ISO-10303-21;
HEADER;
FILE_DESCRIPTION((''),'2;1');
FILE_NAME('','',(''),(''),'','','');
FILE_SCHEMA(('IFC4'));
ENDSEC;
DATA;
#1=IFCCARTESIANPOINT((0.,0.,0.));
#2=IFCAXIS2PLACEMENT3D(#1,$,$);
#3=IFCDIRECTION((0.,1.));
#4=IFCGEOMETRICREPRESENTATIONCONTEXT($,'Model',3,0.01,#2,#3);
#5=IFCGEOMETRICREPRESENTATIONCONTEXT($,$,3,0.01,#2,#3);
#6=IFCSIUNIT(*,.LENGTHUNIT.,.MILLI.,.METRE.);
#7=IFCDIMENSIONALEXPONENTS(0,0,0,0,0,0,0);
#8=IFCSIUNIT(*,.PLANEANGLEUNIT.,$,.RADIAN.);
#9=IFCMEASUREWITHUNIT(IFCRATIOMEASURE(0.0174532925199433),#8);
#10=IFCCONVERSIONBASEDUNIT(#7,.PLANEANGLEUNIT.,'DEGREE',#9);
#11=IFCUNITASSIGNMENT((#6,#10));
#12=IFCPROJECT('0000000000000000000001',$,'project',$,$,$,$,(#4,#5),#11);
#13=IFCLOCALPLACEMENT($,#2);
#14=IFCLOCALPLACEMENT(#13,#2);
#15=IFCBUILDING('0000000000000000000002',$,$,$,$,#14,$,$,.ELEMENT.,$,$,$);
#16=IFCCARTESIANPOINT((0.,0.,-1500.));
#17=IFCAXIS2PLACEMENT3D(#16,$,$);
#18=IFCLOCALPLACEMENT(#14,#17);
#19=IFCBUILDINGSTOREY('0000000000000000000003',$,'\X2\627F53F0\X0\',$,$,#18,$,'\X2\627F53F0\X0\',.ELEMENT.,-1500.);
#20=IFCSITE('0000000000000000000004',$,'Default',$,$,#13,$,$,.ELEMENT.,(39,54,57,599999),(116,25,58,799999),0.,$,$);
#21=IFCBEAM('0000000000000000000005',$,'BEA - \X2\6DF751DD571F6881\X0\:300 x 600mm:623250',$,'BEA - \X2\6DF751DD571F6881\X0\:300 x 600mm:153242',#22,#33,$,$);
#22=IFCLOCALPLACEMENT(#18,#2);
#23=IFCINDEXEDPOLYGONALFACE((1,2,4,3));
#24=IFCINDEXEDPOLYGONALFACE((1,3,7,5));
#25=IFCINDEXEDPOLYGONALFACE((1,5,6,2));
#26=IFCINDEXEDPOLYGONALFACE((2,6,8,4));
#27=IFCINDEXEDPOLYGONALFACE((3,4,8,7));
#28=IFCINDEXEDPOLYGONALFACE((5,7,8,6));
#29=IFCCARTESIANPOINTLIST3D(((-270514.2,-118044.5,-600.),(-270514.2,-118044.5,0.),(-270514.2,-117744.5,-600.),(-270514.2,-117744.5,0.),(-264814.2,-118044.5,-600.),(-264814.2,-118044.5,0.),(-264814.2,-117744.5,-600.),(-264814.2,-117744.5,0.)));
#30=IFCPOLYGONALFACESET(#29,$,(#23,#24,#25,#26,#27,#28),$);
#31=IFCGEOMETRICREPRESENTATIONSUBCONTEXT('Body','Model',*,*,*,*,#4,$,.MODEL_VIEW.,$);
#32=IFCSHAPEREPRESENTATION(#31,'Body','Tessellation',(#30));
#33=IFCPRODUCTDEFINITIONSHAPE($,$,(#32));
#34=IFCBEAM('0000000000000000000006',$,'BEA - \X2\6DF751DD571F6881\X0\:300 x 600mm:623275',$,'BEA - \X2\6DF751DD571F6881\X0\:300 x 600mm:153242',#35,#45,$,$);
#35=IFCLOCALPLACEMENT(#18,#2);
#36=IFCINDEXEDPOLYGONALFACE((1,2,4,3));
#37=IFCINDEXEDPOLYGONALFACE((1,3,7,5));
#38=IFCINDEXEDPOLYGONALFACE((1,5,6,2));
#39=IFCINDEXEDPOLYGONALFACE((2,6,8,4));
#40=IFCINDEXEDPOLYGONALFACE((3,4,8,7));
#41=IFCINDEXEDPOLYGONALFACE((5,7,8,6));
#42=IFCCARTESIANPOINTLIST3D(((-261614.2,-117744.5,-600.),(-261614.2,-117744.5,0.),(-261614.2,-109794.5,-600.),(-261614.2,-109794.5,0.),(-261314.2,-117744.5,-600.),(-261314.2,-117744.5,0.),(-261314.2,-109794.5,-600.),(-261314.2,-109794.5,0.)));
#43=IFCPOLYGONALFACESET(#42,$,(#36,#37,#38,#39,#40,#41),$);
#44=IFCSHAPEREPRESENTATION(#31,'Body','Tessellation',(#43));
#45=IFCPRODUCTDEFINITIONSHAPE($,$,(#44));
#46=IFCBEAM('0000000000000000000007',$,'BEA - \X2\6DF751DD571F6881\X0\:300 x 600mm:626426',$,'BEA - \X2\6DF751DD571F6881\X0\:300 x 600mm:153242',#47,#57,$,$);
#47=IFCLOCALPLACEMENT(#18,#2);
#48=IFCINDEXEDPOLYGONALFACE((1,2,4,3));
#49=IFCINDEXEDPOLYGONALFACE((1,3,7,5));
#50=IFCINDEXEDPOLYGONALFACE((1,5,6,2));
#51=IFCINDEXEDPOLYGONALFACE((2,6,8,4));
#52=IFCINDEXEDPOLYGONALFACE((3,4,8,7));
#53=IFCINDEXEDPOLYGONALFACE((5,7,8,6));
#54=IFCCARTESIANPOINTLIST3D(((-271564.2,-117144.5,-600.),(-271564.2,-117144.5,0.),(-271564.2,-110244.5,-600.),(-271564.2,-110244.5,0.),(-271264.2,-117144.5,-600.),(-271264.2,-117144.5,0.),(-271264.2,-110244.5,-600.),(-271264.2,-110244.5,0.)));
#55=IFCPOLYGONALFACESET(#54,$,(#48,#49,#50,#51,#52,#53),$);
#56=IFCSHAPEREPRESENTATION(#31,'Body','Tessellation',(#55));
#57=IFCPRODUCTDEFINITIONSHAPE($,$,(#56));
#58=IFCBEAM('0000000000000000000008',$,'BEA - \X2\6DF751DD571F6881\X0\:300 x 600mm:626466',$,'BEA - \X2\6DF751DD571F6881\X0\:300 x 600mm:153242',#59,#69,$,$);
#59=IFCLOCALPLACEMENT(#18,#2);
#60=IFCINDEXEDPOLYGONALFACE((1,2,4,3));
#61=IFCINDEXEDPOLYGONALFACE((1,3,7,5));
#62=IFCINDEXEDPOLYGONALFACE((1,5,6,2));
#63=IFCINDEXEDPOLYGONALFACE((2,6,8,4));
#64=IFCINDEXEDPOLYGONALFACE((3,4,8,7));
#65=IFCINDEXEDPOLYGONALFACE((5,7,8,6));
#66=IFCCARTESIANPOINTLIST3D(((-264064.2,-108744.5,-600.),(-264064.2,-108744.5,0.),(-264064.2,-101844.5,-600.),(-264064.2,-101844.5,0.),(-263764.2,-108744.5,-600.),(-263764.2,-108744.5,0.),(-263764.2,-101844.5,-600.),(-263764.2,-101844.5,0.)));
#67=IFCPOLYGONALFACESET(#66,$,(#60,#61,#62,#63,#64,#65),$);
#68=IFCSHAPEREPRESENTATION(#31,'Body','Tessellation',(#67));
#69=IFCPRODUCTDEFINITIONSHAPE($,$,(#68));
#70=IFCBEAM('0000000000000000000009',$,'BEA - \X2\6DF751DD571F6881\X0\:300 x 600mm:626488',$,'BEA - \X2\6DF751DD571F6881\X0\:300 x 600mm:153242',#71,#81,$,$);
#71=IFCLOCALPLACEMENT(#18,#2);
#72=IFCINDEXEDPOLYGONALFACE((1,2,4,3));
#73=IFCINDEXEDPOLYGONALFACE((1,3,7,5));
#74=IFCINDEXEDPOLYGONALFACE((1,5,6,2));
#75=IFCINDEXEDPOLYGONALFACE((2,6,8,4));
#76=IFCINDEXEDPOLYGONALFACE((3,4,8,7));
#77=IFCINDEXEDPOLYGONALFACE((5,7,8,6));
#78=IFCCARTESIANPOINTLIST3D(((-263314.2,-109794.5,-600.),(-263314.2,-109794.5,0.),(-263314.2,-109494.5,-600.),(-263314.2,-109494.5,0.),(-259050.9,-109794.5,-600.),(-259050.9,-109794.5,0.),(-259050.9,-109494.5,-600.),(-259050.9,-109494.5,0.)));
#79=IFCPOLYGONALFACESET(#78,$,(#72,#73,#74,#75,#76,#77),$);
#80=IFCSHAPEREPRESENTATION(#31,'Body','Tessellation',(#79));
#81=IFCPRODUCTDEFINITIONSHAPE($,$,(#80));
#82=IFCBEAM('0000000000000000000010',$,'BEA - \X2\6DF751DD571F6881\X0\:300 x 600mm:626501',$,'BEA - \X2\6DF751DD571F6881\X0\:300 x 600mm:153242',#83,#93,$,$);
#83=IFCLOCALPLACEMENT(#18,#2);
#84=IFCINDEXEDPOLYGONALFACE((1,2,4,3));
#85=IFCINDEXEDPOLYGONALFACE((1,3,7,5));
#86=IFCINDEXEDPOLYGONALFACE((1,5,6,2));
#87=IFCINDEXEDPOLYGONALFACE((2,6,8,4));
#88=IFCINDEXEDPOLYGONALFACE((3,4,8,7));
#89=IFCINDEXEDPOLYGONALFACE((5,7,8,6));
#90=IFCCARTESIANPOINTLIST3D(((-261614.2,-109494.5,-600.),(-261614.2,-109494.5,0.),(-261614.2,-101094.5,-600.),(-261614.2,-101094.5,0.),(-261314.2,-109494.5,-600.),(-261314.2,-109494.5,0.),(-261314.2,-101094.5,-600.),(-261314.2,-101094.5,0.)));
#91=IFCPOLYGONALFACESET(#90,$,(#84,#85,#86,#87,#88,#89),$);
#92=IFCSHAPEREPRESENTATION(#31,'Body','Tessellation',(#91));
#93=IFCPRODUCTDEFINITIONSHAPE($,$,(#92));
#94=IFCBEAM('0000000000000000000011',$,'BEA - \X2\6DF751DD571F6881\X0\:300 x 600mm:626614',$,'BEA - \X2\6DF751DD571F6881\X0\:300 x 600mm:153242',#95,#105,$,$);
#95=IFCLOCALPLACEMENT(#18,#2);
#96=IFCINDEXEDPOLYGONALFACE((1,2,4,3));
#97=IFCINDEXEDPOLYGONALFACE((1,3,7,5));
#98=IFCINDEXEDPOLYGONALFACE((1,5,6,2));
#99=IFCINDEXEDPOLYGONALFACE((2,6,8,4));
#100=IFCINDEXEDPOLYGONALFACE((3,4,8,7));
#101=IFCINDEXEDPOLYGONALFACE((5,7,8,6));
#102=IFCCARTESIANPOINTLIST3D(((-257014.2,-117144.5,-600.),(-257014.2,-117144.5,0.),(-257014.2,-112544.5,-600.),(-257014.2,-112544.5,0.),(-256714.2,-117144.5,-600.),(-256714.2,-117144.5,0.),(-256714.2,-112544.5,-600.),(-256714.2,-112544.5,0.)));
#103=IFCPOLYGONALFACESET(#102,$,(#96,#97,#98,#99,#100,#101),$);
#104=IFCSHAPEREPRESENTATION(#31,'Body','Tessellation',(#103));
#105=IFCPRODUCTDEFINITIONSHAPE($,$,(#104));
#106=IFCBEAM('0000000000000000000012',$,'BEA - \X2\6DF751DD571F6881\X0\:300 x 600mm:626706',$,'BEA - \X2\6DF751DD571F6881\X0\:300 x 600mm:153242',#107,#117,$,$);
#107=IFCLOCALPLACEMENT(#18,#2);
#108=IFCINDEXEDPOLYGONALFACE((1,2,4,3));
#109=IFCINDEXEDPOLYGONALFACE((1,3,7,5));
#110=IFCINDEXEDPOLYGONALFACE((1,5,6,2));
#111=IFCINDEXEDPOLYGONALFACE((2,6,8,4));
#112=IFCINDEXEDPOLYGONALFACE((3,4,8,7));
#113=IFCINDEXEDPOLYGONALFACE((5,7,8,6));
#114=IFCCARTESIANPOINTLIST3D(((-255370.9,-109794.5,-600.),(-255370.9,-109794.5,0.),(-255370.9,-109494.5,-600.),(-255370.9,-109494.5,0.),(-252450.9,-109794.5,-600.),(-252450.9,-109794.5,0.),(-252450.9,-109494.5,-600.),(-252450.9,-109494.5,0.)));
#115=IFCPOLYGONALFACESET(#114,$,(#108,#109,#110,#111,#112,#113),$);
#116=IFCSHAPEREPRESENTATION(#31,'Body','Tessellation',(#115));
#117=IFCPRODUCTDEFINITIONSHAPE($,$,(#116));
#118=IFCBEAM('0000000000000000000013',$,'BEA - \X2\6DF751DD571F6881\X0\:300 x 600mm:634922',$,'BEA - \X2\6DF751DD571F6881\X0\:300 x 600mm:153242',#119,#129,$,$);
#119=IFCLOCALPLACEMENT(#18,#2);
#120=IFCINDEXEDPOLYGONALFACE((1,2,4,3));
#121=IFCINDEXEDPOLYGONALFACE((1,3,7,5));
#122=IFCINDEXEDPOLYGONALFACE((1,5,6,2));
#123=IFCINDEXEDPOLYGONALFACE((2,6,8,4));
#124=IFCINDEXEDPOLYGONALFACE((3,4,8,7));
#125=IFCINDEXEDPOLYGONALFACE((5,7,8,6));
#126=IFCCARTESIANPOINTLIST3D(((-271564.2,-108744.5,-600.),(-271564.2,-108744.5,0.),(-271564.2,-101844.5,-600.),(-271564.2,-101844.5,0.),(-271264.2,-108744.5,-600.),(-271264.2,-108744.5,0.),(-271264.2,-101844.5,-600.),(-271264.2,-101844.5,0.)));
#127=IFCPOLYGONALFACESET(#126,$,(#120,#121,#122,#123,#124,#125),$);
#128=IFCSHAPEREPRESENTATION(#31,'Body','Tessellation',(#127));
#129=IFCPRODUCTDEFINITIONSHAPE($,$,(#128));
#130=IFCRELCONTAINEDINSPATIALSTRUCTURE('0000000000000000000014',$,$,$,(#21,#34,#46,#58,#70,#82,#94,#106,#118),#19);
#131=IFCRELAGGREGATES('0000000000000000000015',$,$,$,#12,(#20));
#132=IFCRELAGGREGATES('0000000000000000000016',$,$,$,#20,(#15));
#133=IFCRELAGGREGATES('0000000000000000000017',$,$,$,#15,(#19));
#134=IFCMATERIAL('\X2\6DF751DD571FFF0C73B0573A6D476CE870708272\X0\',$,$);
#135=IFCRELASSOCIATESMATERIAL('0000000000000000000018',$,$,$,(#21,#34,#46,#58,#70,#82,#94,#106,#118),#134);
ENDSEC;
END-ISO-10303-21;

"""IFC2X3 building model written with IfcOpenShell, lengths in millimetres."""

from ifc_helpers import new_model, entity, si_unit, converted_unit, direction, frame, frame_2d, origin, origin_2d_with_axis, place, context, subcontext, project, spatial, rectangle, extrude, material, element, save


model = new_model("IFC2X3")

# Units and contexts
model_context = context("Model", 3, precision=0.01, world=origin(), true_north=direction((0.0, 1.0)))
context_of_model = context(None, 3, precision=0.01, world=origin(), true_north=direction((0.0, 1.0)))
body_context = subcontext(model_context, "Body", "Model", "MODEL_VIEW")
ifc_project = project(units=[si_unit("LENGTHUNIT", "METRE", prefix="MILLI"), converted_unit("PLANEANGLEUNIT", "DEGREE", entity("IfcRatioMeasure", 0.0174532925199433), si_unit("PLANEANGLEUNIT", "RADIAN"), dimensions=[0, 0, 0, 0, 0, 0, 0])], contexts=[model_context, context_of_model])

# Site, building, storey
site_placement = place(None, origin())
site = spatial("IfcSite", under=ifc_project, at=site_placement, Name="Default", CompositionType="ELEMENT", RefLatitude=(39, 54, 57, 599999), RefLongitude=(116, 25, 58, 799999), RefElevation=0.0)
building_placement = place(site_placement, origin())
building = spatial("IfcBuilding", under=site, at=building_placement, CompositionType="ELEMENT")
storey_placement = place(building_placement, frame((0.0, 0.0, -1500.0)))
storey = spatial("IfcBuildingStorey", under=building, at=storey_placement, Name="承台", LongName="承台", CompositionType="ELEMENT", Elevation=-1500.0)

# Shared definitions
ifc_material_1 = material(Name="混凝土，现场浇注灰色")

# Beams
beam_1_placement = place(storey_placement, frame((-264814.2, -117894.5, 0.0), z_axis=(0.0, 0.0, 1.0), x_axis=(-1.0, 0.0, 0.0)))
element("IfcBeam", 1, at=beam_1_placement, inside=storey, material=ifc_material_1, Name="BEA - 混凝土梁:300 x 600mm:623250", ObjectType="BEA - 混凝土梁:300 x 600mm:153242", context=body_context, shape_type="SweptSolid", body=[
    extrude(rectangle(XDim=600.0, YDim=300.0, at=frame_2d((0.0, 0.0), x_axis=(1.0, 0.0))), frame((0.0, 0.0, -300.0), z_axis=(1.0, 0.0, 0.0), x_axis=(0.0, 0.0, -1.0)), (0.0, 0.0, 1.0), 5700.0),
])
beam_2_placement = place(storey_placement, frame((-261464.2, -117744.5, 0.0), z_axis=(0.0, 0.0, 1.0), x_axis=(0.0, 1.0, 0.0)))
element("IfcBeam", 2, at=beam_2_placement, inside=storey, material=ifc_material_1, Name="BEA - 混凝土梁:300 x 600mm:623275", ObjectType="BEA - 混凝土梁:300 x 600mm:153242", context=body_context, shape_type="SweptSolid", body=[
    extrude(rectangle(XDim=600.0, YDim=300.0, at=origin_2d_with_axis()), frame((0.0, 0.0, -300.0), z_axis=(1.0, 0.0, 0.0), x_axis=(0.0, 0.0, -1.0)), (0.0, 0.0, 1.0), 7950.0),
])
for number, where, z_axis, x_axis, name in (
    (3, (-271414.2, -110244.5, 0.0), (0.0, 0.0, 1.0), (0.0, -1.0, 0.0), "BEA - 混凝土梁:300 x 600mm:626426"),
    (4, (-263914.2, -108744.5, 0.0), (0.0, 0.0, 1.0), (0.0, 1.0, 0.0), "BEA - 混凝土梁:300 x 600mm:626466"),
):
    element("IfcBeam", number, at=place(storey_placement, frame(where, z_axis=z_axis, x_axis=x_axis)), inside=storey, material=ifc_material_1, Name=name, ObjectType="BEA - 混凝土梁:300 x 600mm:153242", context=body_context, shape_type="SweptSolid", body=[
        extrude(rectangle(XDim=600.0, YDim=300.0, at=origin_2d_with_axis()), frame((0.0, 0.0, -300.0), z_axis=(1.0, 0.0, 0.0), x_axis=(0.0, 0.0, -1.0)), (0.0, 0.0, 1.0), 6900.0),
    ])
beam_3_placement = place(storey_placement, frame((-263314.2, -109644.5, 0.0)))
element("IfcBeam", 5, at=beam_3_placement, inside=storey, material=ifc_material_1, Name="BEA - 混凝土梁:300 x 600mm:626488", ObjectType="BEA - 混凝土梁:300 x 600mm:153242", context=body_context, shape_type="SweptSolid", body=[
    extrude(rectangle(XDim=600.0, YDim=300.0, at=frame_2d((0.0, 0.0), x_axis=(1.0, 0.0))), frame((0.0, 0.0, -300.0), z_axis=(1.0, 0.0, 0.0), x_axis=(0.0, 0.0, -1.0)), (0.0, 0.0, 1.0), 4263.3),
])
beam_4_placement = place(storey_placement, frame((-261464.2, -109494.5, 0.0), z_axis=(0.0, 0.0, 1.0), x_axis=(0.0, 1.0, 0.0)))
element("IfcBeam", 6, at=beam_4_placement, inside=storey, material=ifc_material_1, Name="BEA - 混凝土梁:300 x 600mm:626501", ObjectType="BEA - 混凝土梁:300 x 600mm:153242", context=body_context, shape_type="SweptSolid", body=[
    extrude(rectangle(XDim=600.0, YDim=300.0, at=origin_2d_with_axis()), frame((0.0, 0.0, -300.0), z_axis=(1.0, 0.0, 0.0), x_axis=(0.0, 0.0, -1.0)), (0.0, 0.0, 1.0), 8400.0),
])
beam_5_placement = place(storey_placement, frame((-256864.2, -112544.5, 0.0), z_axis=(0.0, 0.0, 1.0), x_axis=(0.0, -1.0, 0.0)))
element("IfcBeam", 7, at=beam_5_placement, inside=storey, material=ifc_material_1, Name="BEA - 混凝土梁:300 x 600mm:626614", ObjectType="BEA - 混凝土梁:300 x 600mm:153242", context=body_context, shape_type="SweptSolid", body=[
    extrude(rectangle(XDim=600.0, YDim=300.0, at=origin_2d_with_axis()), frame((0.0, 0.0, -300.0), z_axis=(1.0, 0.0, 0.0), x_axis=(0.0, 0.0, -1.0)), (0.0, 0.0, 1.0), 4600.0),
])
beam_6_placement = place(storey_placement, frame((-255370.9, -109644.5, 0.0)))
element("IfcBeam", 8, at=beam_6_placement, inside=storey, material=ifc_material_1, Name="BEA - 混凝土梁:300 x 600mm:626706", ObjectType="BEA - 混凝土梁:300 x 600mm:153242", context=body_context, shape_type="SweptSolid", body=[
    extrude(rectangle(XDim=600.0, YDim=300.0, at=frame_2d((0.0, 0.0), x_axis=(1.0, 0.0))), frame((0.0, 0.0, -300.0), z_axis=(1.0, 0.0, 0.0), x_axis=(0.0, 0.0, -1.0)), (0.0, 0.0, 1.0), 2920.0),
])
beam_7_placement = place(storey_placement, frame((-271414.2, -101844.5, 0.0), z_axis=(0.0, 0.0, 1.0), x_axis=(0.0, -1.0, 0.0)))
element("IfcBeam", 9, at=beam_7_placement, inside=storey, material=ifc_material_1, Name="BEA - 混凝土梁:300 x 600mm:634922", ObjectType="BEA - 混凝土梁:300 x 600mm:153242", context=body_context, shape_type="SweptSolid", body=[
    extrude(rectangle(XDim=600.0, YDim=300.0, at=origin_2d_with_axis()), frame((0.0, 0.0, -300.0), z_axis=(1.0, 0.0, 0.0), x_axis=(0.0, 0.0, -1.0)), (0.0, 0.0, 1.0), 6900.0),
])

save(model, "model.ifc")
